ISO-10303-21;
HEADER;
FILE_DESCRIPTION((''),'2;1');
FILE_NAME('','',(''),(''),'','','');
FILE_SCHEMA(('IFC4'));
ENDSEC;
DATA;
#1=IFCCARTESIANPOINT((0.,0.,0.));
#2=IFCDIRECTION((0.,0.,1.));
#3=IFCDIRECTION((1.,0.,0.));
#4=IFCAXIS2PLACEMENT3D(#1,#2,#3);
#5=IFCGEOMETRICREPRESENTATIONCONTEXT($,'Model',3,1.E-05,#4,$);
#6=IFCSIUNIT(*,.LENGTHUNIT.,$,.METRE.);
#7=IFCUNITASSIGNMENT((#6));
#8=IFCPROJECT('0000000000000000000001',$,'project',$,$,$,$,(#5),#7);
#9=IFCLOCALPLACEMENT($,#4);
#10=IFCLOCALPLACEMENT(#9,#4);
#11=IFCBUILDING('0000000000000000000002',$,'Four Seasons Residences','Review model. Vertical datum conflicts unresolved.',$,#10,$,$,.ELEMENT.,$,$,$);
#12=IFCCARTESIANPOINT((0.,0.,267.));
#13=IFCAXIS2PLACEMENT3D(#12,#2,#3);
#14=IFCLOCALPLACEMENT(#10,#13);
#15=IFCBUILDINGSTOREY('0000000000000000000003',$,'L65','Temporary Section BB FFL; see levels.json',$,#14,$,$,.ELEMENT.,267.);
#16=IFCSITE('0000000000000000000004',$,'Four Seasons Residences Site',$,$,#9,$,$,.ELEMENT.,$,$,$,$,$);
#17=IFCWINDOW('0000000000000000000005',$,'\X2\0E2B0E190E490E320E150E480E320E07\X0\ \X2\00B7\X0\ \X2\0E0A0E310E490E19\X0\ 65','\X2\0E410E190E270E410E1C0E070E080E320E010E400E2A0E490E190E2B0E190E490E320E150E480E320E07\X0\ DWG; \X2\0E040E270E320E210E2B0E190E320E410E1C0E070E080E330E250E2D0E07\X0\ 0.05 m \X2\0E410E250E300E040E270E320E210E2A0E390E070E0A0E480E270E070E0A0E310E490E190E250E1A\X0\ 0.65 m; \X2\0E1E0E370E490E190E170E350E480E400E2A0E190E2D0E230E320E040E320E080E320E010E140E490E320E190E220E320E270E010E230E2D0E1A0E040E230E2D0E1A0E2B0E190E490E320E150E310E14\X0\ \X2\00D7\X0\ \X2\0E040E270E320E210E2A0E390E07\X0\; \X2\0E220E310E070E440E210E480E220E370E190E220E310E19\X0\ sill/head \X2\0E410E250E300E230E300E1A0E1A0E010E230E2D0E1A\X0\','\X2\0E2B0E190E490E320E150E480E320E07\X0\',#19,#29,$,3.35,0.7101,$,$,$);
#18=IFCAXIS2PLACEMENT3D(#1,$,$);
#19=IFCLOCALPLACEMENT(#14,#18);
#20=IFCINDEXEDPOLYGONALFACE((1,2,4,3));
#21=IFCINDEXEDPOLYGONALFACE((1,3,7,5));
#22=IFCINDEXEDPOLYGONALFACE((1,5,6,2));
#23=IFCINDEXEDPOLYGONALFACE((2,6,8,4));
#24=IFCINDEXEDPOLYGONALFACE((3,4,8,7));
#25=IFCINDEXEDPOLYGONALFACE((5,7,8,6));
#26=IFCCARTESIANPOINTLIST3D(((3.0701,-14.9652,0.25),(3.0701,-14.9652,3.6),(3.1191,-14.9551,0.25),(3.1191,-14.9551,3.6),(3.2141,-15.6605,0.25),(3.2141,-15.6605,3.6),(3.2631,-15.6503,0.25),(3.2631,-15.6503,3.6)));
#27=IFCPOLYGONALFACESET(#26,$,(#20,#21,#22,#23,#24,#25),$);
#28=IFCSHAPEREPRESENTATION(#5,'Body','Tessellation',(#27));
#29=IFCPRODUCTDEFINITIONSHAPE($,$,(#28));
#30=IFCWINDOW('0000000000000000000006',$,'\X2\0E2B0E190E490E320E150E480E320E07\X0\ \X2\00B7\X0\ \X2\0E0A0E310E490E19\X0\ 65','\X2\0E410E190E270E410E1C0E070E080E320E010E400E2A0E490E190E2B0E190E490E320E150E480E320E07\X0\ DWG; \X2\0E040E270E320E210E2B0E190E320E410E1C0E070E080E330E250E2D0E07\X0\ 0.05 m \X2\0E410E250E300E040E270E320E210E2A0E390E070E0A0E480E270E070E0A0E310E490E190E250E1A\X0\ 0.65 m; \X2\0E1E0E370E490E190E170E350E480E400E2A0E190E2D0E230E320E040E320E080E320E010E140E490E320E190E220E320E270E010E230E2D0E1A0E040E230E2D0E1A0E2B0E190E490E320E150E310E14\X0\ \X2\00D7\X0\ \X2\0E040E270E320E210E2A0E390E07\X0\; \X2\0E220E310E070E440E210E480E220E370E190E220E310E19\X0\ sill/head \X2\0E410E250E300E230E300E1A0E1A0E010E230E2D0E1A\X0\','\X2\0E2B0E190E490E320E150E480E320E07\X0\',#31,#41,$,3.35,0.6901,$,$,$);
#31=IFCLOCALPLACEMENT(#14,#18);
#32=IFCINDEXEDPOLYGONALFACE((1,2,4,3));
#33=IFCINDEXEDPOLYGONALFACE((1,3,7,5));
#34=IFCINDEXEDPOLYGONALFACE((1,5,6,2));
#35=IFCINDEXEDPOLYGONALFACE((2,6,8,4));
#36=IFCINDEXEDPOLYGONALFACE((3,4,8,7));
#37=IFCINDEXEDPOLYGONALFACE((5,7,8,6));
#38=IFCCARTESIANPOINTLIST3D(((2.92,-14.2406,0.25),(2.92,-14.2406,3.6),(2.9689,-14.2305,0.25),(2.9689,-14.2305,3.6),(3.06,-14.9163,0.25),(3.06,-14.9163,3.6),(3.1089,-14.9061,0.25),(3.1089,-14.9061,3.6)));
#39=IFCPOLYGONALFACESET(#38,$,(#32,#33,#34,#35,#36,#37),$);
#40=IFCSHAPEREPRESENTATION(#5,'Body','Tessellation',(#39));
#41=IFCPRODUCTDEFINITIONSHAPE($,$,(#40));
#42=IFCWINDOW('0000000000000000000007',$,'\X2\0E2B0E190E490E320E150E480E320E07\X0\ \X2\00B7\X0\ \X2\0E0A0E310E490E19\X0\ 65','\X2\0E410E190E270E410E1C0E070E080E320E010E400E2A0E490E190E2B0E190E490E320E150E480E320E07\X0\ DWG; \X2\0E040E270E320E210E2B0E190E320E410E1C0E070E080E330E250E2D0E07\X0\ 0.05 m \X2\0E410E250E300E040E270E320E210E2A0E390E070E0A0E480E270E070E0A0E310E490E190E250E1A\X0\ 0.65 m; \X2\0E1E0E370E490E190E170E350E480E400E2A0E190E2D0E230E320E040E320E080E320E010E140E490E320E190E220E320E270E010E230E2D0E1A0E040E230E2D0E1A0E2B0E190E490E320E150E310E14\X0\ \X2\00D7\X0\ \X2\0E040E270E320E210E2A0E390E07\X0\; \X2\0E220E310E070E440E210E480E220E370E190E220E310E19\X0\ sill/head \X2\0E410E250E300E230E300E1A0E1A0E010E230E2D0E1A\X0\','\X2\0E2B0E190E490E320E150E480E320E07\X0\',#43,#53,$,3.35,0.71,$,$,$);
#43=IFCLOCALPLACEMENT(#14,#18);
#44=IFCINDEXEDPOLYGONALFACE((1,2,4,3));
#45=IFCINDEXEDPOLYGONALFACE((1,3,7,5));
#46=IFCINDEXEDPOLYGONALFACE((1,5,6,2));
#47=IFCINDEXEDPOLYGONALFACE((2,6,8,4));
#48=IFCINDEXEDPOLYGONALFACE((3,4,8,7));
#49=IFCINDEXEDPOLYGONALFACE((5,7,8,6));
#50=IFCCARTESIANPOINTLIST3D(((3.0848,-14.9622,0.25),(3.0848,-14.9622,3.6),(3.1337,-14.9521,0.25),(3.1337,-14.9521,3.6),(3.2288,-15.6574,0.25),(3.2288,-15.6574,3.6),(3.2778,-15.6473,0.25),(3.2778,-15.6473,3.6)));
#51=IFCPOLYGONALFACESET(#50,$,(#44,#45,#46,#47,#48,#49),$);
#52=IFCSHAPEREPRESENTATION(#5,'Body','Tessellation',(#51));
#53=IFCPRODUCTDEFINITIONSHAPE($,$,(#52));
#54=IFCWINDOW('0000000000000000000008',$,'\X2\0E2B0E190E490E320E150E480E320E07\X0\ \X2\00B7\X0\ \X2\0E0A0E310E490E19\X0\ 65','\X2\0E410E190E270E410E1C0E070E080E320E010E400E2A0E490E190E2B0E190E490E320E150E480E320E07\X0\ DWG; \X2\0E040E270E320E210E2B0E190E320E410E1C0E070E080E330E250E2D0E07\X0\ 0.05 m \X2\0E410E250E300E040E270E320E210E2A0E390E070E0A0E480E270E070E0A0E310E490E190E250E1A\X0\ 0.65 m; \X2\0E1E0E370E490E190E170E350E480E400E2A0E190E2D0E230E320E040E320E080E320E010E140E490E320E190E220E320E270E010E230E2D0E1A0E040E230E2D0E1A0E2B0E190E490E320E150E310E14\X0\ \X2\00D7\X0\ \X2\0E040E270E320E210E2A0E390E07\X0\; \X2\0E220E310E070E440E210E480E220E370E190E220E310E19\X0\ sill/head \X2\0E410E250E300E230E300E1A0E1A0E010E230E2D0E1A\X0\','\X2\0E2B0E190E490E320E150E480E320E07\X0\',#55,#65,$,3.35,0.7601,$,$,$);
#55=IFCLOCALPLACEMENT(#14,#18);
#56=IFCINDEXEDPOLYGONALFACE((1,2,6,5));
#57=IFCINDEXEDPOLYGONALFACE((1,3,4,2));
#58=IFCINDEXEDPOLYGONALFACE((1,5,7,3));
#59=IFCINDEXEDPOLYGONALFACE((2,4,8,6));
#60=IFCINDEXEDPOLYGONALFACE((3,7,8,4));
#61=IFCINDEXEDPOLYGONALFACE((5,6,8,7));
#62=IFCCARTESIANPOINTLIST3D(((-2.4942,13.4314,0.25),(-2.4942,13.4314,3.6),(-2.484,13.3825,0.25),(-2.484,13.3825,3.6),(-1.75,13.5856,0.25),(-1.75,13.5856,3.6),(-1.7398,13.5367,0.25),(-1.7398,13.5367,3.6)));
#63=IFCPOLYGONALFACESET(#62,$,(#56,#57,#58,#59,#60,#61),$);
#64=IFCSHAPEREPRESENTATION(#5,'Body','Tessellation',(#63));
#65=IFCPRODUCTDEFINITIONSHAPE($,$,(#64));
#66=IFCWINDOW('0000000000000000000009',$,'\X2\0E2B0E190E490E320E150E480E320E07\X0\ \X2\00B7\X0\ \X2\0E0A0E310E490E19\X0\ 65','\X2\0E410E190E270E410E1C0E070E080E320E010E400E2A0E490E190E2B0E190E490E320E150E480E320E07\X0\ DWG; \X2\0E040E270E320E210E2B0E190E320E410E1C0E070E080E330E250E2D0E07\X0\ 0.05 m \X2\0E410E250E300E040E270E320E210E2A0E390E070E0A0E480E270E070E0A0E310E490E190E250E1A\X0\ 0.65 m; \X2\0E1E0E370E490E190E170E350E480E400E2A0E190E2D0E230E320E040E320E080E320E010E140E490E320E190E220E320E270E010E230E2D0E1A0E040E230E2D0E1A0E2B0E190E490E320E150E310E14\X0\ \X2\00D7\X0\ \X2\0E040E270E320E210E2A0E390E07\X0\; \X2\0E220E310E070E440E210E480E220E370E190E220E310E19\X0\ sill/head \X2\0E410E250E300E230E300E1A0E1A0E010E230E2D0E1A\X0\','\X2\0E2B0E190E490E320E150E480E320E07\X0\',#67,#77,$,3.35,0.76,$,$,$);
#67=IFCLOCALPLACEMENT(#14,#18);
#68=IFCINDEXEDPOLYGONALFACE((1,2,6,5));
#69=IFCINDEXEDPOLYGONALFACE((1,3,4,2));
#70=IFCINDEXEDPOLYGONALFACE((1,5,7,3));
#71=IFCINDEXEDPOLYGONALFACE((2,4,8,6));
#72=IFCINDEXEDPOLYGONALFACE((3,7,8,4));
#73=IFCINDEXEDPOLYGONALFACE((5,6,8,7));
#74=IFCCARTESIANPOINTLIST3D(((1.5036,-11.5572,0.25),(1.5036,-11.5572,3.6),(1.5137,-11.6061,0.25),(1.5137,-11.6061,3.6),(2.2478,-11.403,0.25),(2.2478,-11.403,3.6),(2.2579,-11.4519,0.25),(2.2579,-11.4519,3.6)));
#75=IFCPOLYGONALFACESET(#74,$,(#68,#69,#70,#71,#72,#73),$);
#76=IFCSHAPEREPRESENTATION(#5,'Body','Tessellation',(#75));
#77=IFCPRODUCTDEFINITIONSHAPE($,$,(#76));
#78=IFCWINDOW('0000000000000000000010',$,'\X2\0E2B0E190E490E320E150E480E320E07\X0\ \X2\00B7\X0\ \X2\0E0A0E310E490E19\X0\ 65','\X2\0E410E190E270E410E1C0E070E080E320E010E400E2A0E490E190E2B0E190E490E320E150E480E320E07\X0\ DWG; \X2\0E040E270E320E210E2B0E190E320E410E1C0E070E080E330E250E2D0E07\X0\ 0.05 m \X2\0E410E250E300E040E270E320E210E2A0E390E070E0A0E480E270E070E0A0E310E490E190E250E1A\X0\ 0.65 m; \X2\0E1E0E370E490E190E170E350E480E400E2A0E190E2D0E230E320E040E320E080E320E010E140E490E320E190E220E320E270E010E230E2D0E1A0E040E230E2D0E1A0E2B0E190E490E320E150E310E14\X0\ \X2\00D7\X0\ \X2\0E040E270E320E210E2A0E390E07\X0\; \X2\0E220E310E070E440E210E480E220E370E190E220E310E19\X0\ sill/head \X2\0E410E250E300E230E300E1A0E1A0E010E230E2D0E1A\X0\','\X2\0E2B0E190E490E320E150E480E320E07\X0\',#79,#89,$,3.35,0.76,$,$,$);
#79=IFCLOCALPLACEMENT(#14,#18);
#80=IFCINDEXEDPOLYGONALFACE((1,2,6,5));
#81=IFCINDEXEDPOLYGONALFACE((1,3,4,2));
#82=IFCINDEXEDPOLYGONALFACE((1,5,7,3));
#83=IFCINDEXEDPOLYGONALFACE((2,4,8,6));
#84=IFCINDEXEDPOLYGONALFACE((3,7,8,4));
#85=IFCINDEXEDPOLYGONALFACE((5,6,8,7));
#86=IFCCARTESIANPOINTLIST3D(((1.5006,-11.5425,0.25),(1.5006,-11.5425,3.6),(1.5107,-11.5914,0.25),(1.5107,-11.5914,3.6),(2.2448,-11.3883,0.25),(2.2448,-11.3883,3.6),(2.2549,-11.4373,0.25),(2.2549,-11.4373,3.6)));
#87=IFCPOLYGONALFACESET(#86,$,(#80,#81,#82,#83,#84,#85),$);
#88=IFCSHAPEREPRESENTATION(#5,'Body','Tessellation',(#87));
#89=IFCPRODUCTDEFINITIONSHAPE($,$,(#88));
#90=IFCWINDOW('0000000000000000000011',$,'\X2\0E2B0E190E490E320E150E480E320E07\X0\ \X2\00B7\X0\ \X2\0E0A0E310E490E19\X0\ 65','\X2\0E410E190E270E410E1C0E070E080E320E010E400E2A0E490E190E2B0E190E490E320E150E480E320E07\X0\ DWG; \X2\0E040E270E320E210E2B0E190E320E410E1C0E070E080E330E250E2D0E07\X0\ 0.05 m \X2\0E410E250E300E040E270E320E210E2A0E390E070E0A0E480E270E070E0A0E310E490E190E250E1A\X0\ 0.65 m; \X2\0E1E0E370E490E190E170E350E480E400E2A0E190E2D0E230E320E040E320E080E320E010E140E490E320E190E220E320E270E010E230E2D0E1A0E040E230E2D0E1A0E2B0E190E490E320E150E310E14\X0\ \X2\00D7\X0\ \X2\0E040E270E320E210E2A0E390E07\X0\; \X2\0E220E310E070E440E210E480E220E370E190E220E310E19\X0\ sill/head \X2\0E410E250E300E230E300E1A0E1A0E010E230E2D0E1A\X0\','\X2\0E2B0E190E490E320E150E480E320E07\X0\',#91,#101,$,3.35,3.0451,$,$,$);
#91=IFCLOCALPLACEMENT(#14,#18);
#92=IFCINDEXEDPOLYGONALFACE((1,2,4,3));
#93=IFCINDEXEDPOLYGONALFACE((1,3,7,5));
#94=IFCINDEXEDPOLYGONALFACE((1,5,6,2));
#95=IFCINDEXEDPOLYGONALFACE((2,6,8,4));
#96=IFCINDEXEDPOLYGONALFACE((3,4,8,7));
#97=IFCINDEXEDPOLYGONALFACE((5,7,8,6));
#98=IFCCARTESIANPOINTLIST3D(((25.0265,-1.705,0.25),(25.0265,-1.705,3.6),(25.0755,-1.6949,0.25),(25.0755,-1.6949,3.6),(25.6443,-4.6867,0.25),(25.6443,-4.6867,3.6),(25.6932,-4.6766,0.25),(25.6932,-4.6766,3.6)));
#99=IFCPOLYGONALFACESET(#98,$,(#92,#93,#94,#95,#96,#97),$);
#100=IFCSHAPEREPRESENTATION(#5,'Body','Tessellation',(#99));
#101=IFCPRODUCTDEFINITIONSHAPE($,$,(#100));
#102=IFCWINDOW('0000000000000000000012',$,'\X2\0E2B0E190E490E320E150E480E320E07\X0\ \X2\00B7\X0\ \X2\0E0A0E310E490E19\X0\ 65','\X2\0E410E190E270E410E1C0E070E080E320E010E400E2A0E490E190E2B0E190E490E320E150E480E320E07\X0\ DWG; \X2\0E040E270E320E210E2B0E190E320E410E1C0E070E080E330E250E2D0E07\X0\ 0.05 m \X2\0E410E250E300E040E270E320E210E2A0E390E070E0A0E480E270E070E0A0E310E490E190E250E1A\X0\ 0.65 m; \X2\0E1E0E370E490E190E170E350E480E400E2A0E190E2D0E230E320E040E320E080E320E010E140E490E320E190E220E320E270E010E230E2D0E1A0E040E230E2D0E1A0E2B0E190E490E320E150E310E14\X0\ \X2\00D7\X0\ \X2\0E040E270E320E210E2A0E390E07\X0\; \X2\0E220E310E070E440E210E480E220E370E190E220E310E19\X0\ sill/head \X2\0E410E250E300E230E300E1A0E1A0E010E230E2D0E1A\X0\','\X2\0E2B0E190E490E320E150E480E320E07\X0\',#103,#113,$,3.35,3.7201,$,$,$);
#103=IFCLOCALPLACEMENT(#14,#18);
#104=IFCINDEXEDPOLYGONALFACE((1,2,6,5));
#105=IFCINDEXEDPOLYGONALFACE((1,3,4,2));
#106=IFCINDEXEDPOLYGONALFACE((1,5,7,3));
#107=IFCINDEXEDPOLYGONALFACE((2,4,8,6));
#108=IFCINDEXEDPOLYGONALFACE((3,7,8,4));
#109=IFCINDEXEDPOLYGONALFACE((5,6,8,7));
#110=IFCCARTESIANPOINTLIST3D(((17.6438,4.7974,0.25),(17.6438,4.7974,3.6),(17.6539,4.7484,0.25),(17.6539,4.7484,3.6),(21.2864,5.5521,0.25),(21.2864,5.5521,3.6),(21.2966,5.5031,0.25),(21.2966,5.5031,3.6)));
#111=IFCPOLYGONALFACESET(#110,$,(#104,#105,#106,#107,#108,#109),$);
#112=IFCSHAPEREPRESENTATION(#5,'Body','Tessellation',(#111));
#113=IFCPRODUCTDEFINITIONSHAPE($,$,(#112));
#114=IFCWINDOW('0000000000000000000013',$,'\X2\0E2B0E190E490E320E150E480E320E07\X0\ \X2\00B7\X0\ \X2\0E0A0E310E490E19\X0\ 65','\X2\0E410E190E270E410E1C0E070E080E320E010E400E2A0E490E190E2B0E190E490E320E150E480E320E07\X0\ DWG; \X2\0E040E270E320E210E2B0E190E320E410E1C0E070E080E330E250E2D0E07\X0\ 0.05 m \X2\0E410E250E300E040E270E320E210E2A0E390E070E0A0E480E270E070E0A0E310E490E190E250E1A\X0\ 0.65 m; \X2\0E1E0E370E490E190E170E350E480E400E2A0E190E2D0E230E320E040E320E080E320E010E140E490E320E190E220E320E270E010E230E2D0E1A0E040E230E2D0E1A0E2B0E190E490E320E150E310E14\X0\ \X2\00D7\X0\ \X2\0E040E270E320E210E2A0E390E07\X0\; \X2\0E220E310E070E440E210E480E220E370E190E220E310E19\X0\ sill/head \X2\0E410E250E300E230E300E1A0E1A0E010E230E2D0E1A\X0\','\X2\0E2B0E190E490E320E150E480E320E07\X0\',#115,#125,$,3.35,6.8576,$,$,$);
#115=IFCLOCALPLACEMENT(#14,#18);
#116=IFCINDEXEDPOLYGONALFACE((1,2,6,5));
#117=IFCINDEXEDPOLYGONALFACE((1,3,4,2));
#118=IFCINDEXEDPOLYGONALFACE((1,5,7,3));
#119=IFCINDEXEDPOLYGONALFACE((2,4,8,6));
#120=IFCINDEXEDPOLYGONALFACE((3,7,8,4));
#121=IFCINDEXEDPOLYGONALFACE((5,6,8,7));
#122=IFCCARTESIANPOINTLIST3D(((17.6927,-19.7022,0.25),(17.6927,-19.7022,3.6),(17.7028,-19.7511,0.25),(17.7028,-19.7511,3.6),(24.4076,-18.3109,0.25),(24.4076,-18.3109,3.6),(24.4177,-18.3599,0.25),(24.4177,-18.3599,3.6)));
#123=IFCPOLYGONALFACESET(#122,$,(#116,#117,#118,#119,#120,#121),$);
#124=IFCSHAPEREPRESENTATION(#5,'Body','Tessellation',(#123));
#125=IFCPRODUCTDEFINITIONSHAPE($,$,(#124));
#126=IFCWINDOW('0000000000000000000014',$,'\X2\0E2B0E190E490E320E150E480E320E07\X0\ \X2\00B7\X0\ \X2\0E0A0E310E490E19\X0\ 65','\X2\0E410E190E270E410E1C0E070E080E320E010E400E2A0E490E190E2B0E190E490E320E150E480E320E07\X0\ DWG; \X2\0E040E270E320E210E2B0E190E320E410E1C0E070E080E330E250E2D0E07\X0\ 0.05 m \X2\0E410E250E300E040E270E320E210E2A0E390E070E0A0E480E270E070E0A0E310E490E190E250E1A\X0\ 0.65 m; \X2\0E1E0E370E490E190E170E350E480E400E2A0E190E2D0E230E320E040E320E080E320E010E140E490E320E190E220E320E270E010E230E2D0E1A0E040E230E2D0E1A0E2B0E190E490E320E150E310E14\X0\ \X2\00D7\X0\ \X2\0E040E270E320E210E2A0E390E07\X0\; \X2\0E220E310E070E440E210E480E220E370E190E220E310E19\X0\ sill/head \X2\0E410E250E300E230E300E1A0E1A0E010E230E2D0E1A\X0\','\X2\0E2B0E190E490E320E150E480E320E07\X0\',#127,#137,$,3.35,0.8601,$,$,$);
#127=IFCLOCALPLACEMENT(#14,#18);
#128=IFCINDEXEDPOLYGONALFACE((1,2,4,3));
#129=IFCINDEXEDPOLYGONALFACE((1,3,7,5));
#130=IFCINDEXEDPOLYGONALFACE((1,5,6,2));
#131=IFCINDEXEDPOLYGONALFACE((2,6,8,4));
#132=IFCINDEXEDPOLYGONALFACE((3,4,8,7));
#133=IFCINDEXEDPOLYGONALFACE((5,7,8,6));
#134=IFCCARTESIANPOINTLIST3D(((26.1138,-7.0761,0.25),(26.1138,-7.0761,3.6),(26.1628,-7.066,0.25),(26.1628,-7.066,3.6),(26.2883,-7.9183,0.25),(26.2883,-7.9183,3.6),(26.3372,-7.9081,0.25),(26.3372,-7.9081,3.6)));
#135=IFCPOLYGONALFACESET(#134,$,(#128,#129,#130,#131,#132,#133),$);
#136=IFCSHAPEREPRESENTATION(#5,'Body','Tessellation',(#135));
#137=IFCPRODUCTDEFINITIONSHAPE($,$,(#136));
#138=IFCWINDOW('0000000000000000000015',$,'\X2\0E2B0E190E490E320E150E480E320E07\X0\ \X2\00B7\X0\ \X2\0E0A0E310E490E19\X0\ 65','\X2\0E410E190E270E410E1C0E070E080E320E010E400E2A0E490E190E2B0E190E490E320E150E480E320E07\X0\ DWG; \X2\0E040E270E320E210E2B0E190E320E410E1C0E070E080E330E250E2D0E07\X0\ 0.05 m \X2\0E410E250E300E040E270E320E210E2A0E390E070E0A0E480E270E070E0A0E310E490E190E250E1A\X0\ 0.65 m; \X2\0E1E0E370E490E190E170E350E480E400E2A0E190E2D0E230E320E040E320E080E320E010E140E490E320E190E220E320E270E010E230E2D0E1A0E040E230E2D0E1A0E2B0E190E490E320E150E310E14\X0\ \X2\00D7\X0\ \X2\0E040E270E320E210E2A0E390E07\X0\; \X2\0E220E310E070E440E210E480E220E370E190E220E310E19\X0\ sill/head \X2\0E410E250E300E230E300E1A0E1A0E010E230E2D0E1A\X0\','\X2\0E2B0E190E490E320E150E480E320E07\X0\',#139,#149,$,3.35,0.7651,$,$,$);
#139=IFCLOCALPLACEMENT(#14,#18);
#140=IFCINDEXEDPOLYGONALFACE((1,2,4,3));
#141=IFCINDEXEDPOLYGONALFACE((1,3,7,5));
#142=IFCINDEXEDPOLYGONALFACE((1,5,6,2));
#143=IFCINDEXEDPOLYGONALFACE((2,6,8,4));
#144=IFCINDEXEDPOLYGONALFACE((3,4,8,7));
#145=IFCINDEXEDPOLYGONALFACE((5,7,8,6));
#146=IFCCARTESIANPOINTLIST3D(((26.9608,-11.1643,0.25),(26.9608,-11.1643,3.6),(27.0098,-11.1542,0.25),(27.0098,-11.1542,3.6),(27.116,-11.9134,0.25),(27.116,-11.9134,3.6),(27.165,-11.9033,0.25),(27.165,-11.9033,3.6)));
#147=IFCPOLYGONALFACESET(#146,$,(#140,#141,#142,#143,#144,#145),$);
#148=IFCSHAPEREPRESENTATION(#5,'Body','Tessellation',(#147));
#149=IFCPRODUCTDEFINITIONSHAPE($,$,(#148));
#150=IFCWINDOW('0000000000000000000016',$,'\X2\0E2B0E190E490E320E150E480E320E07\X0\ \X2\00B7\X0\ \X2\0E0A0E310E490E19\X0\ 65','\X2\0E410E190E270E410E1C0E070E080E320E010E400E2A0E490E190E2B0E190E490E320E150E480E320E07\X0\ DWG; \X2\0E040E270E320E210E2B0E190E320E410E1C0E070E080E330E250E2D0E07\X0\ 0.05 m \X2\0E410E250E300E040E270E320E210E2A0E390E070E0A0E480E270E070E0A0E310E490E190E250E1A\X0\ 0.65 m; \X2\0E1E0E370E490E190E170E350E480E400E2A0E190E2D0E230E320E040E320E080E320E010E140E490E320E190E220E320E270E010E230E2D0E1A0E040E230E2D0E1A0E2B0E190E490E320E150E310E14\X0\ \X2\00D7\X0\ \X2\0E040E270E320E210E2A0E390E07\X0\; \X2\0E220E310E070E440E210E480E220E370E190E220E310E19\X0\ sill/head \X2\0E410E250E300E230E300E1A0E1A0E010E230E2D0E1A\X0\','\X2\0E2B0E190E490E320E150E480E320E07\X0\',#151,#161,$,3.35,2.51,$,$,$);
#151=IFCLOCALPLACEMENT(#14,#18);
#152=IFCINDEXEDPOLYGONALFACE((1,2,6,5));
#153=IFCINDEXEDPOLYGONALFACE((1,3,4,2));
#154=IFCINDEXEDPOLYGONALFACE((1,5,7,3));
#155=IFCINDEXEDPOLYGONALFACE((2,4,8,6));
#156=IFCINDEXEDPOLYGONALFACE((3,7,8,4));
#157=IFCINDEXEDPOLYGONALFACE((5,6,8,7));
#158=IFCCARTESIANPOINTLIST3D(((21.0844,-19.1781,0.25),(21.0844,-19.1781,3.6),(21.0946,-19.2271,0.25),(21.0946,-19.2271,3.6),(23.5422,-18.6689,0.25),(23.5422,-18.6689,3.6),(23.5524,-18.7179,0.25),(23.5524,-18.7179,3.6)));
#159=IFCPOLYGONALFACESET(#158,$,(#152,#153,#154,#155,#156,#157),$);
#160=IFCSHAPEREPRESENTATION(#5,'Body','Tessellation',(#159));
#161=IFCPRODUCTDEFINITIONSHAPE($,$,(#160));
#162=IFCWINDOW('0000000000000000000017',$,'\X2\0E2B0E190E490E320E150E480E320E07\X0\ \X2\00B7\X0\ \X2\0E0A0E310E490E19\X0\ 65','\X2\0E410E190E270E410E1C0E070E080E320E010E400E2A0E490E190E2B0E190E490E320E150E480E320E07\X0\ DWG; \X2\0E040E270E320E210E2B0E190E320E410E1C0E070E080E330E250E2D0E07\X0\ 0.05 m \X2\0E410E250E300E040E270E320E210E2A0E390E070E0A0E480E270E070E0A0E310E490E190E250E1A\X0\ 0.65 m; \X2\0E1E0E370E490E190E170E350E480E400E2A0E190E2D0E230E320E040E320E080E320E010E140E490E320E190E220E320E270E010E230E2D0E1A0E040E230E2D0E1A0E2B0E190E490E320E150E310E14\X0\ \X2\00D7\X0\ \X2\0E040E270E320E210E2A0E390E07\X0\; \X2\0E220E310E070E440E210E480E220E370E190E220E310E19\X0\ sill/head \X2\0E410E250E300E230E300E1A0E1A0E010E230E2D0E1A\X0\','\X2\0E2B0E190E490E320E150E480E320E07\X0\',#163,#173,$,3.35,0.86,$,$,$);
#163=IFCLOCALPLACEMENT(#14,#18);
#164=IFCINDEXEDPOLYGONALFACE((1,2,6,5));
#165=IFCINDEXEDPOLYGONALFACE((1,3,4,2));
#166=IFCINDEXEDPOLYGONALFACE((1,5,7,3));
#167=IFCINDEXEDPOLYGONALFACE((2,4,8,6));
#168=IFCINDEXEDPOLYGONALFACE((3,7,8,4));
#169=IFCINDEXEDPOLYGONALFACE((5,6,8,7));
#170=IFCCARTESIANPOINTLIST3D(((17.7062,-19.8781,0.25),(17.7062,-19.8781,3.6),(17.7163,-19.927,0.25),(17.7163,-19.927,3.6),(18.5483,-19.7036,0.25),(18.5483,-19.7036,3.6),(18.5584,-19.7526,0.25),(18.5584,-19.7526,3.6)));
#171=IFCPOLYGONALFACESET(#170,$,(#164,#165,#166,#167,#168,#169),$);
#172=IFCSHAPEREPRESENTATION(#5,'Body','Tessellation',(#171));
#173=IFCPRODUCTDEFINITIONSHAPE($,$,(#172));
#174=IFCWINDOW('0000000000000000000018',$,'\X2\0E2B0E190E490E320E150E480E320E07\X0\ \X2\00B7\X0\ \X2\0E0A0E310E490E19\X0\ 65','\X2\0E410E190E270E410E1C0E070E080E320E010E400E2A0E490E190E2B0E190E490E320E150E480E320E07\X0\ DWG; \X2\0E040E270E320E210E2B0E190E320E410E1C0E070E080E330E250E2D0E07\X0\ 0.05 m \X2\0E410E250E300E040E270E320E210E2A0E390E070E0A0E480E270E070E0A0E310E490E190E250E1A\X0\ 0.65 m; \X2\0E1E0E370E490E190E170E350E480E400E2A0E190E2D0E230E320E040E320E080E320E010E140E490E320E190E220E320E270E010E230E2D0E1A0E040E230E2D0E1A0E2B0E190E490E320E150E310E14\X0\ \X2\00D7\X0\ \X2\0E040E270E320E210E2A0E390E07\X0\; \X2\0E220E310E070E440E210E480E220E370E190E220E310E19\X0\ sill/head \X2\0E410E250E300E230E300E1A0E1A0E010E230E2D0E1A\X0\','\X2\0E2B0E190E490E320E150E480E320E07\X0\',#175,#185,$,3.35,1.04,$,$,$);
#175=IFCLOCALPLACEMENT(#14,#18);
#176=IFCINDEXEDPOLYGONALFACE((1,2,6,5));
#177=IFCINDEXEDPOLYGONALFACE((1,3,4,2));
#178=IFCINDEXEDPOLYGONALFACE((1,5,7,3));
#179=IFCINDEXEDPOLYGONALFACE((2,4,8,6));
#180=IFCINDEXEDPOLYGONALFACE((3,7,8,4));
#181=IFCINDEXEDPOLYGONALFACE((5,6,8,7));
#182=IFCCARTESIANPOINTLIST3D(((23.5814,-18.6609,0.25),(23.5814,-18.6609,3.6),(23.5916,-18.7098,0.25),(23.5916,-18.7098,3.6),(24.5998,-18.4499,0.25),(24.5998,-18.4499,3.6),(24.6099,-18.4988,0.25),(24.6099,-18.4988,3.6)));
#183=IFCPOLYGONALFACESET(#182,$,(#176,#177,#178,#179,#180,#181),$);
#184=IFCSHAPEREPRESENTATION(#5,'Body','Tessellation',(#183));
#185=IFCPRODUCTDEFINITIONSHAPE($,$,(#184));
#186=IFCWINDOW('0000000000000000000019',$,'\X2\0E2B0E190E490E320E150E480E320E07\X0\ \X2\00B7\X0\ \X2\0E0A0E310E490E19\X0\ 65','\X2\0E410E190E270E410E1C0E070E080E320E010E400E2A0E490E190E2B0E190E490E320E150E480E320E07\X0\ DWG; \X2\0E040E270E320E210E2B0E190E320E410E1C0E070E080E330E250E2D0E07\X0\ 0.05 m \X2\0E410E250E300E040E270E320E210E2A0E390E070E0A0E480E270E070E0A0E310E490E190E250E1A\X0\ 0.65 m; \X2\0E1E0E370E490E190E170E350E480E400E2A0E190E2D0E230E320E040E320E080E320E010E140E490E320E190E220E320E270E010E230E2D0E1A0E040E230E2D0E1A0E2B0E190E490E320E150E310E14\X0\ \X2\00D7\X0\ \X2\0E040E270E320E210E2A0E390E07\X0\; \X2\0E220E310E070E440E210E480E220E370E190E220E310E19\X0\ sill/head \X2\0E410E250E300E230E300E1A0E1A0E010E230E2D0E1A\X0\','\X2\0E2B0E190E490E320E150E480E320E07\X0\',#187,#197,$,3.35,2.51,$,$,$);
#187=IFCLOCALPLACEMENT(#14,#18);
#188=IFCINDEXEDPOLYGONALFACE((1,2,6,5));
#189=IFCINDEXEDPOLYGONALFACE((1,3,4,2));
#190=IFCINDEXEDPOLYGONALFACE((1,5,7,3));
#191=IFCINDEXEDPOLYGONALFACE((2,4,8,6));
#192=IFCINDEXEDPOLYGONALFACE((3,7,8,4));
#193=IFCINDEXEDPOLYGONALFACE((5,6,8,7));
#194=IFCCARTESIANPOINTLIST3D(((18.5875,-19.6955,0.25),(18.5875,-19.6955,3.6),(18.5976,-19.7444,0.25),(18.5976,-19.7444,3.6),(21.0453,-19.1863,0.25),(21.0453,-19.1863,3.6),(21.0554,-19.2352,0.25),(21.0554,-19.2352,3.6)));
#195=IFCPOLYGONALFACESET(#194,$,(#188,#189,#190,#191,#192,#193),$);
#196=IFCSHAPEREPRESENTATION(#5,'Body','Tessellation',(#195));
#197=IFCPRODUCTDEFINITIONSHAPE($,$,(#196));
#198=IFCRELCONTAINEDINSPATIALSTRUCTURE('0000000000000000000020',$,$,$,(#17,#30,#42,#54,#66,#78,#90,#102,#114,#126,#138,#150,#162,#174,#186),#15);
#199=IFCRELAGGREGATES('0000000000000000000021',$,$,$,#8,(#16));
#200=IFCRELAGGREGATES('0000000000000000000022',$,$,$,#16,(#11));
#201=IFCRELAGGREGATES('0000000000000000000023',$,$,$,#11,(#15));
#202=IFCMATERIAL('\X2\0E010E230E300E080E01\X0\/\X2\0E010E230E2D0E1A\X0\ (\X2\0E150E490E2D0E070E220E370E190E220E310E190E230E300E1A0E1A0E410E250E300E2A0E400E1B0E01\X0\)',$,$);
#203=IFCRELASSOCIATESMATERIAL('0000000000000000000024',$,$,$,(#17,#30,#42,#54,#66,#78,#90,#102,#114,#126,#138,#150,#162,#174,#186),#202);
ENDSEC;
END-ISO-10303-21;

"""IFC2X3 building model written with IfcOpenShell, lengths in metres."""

from ifc_helpers import new_model, si_unit, frame, origin_with_axes, place, context, project, spatial, polyline, outline, extrude, material, element, save


model = new_model("IFC2X3")

# Units and contexts
model_context = context("Model", 3, precision=1e-05, world=origin_with_axes())
ifc_project = project(units=[si_unit("LENGTHUNIT", "METRE")], contexts=[model_context])

# Site, building, storey
site_placement = place(None, origin_with_axes())
site = spatial("IfcSite", under=ifc_project, at=site_placement, Name="Four Seasons Residences Site", CompositionType="ELEMENT")
building_placement = place(site_placement, origin_with_axes())
building = spatial("IfcBuilding", under=site, at=building_placement, Name="Four Seasons Residences", Description="Review model. Vertical datum conflicts unresolved.", CompositionType="ELEMENT")
storey_placement = place(building_placement, frame((0.0, 0.0, 267.0), z_axis=(0.0, 0.0, 1.0), x_axis=(1.0, 0.0, 0.0)))
storey = spatial("IfcBuildingStorey", under=building, at=storey_placement, Name="L65", Description="Temporary Section BB FFL; see levels.json", CompositionType="ELEMENT", Elevation=267.0)

# Windows
ifc_material = material(Name="กระจก/กรอบ (ต้องยืนยันระบบและสเปก)")
window_1_placement = place(storey_placement, origin_with_axes())
element("IfcWindow", 1, at=window_1_placement, inside=storey, material=ifc_material, Name="หน้าต่าง · ชั้น 65", Description="แนวแผงจากเส้นหน้าต่าง DWG; ความหนาแผงจำลอง 0.05 m และความสูงช่วงชั้นลบ 0.65 m; พื้นที่เสนอราคาจากด้านยาวกรอบครอบหน้าตัด × ความสูง; ยังไม่ยืนยัน sill/head และระบบกรอบ", ObjectType="หน้าต่าง", OverallHeight=3.35, OverallWidth=0.7101, context=model_context, shape_type="SweptSolid", body=[
    extrude(outline(polyline([(3.0701, -14.9652), (3.1191, -14.9551), (3.2631, -15.6503), (3.2141, -15.6605), (3.0701, -14.9652)])), frame((0.0, 0.0, 0.25), z_axis=(0.0, 0.0, 1.0), x_axis=(1.0, 0.0, 0.0)), (0.0, 0.0, 1.0), 3.35),
])
window_2_placement = place(storey_placement, origin_with_axes())
element("IfcWindow", 2, at=window_2_placement, inside=storey, material=ifc_material, Name="หน้าต่าง · ชั้น 65", Description="แนวแผงจากเส้นหน้าต่าง DWG; ความหนาแผงจำลอง 0.05 m และความสูงช่วงชั้นลบ 0.65 m; พื้นที่เสนอราคาจากด้านยาวกรอบครอบหน้าตัด × ความสูง; ยังไม่ยืนยัน sill/head และระบบกรอบ", ObjectType="หน้าต่าง", OverallHeight=3.35, OverallWidth=0.6901, context=model_context, shape_type="SweptSolid", body=[
    extrude(outline(polyline([(2.92, -14.2406), (2.9689, -14.2305), (3.1089, -14.9061), (3.06, -14.9163), (2.92, -14.2406)])), frame((0.0, 0.0, 0.25), z_axis=(0.0, 0.0, 1.0), x_axis=(1.0, 0.0, 0.0)), (0.0, 0.0, 1.0), 3.35),
])
window_3_placement = place(storey_placement, origin_with_axes())
element("IfcWindow", 3, at=window_3_placement, inside=storey, material=ifc_material, Name="หน้าต่าง · ชั้น 65", Description="แนวแผงจากเส้นหน้าต่าง DWG; ความหนาแผงจำลอง 0.05 m และความสูงช่วงชั้นลบ 0.65 m; พื้นที่เสนอราคาจากด้านยาวกรอบครอบหน้าตัด × ความสูง; ยังไม่ยืนยัน sill/head และระบบกรอบ", ObjectType="หน้าต่าง", OverallHeight=3.35, OverallWidth=0.71, context=model_context, shape_type="SweptSolid", body=[
    extrude(outline(polyline([(3.0848, -14.9622), (3.1337, -14.9521), (3.2778, -15.6473), (3.2288, -15.6574), (3.0848, -14.9622)])), frame((0.0, 0.0, 0.25), z_axis=(0.0, 0.0, 1.0), x_axis=(1.0, 0.0, 0.0)), (0.0, 0.0, 1.0), 3.35),
])
window_4_placement = place(storey_placement, origin_with_axes())
element("IfcWindow", 4, at=window_4_placement, inside=storey, material=ifc_material, Name="หน้าต่าง · ชั้น 65", Description="แนวแผงจากเส้นหน้าต่าง DWG; ความหนาแผงจำลอง 0.05 m และความสูงช่วงชั้นลบ 0.65 m; พื้นที่เสนอราคาจากด้านยาวกรอบครอบหน้าตัด × ความสูง; ยังไม่ยืนยัน sill/head และระบบกรอบ", ObjectType="หน้าต่าง", OverallHeight=3.35, OverallWidth=0.7601, context=model_context, shape_type="SweptSolid", body=[
    extrude(outline(polyline([(-1.75, 13.5856), (-1.7398, 13.5367), (-2.484, 13.3825), (-2.4942, 13.4314), (-1.75, 13.5856)])), frame((0.0, 0.0, 0.25), z_axis=(0.0, 0.0, 1.0), x_axis=(1.0, 0.0, 0.0)), (0.0, 0.0, 1.0), 3.35),
])
window_5_placement = place(storey_placement, origin_with_axes())
element("IfcWindow", 5, at=window_5_placement, inside=storey, material=ifc_material, Name="หน้าต่าง · ชั้น 65", Description="แนวแผงจากเส้นหน้าต่าง DWG; ความหนาแผงจำลอง 0.05 m และความสูงช่วงชั้นลบ 0.65 m; พื้นที่เสนอราคาจากด้านยาวกรอบครอบหน้าตัด × ความสูง; ยังไม่ยืนยัน sill/head และระบบกรอบ", ObjectType="หน้าต่าง", OverallHeight=3.35, OverallWidth=0.76, context=model_context, shape_type="SweptSolid", body=[
    extrude(outline(polyline([(2.2478, -11.403), (2.2579, -11.4519), (1.5137, -11.6061), (1.5036, -11.5572), (2.2478, -11.403)])), frame((0.0, 0.0, 0.25), z_axis=(0.0, 0.0, 1.0), x_axis=(1.0, 0.0, 0.0)), (0.0, 0.0, 1.0), 3.35),
])
window_6_placement = place(storey_placement, origin_with_axes())
element("IfcWindow", 6, at=window_6_placement, inside=storey, material=ifc_material, Name="หน้าต่าง · ชั้น 65", Description="แนวแผงจากเส้นหน้าต่าง DWG; ความหนาแผงจำลอง 0.05 m และความสูงช่วงชั้นลบ 0.65 m; พื้นที่เสนอราคาจากด้านยาวกรอบครอบหน้าตัด × ความสูง; ยังไม่ยืนยัน sill/head และระบบกรอบ", ObjectType="หน้าต่าง", OverallHeight=3.35, OverallWidth=0.76, context=model_context, shape_type="SweptSolid", body=[
    extrude(outline(polyline([(2.2448, -11.3883), (2.2549, -11.4373), (1.5107, -11.5914), (1.5006, -11.5425), (2.2448, -11.3883)])), frame((0.0, 0.0, 0.25), z_axis=(0.0, 0.0, 1.0), x_axis=(1.0, 0.0, 0.0)), (0.0, 0.0, 1.0), 3.35),
])
window_7_placement = place(storey_placement, origin_with_axes())
element("IfcWindow", 7, at=window_7_placement, inside=storey, material=ifc_material, Name="หน้าต่าง · ชั้น 65", Description="แนวแผงจากเส้นหน้าต่าง DWG; ความหนาแผงจำลอง 0.05 m และความสูงช่วงชั้นลบ 0.65 m; พื้นที่เสนอราคาจากด้านยาวกรอบครอบหน้าตัด × ความสูง; ยังไม่ยืนยัน sill/head และระบบกรอบ", ObjectType="หน้าต่าง", OverallHeight=3.35, OverallWidth=3.0451, context=model_context, shape_type="SweptSolid", body=[
    extrude(outline(polyline([(25.0265, -1.705), (25.0755, -1.6949), (25.6932, -4.6766), (25.6443, -4.6867), (25.0265, -1.705)])), frame((0.0, 0.0, 0.25), z_axis=(0.0, 0.0, 1.0), x_axis=(1.0, 0.0, 0.0)), (0.0, 0.0, 1.0), 3.35),
])
window_8_placement = place(storey_placement, origin_with_axes())
element("IfcWindow", 8, at=window_8_placement, inside=storey, material=ifc_material, Name="หน้าต่าง · ชั้น 65", Description="แนวแผงจากเส้นหน้าต่าง DWG; ความหนาแผงจำลอง 0.05 m และความสูงช่วงชั้นลบ 0.65 m; พื้นที่เสนอราคาจากด้านยาวกรอบครอบหน้าตัด × ความสูง; ยังไม่ยืนยัน sill/head และระบบกรอบ", ObjectType="หน้าต่าง", OverallHeight=3.35, OverallWidth=3.7201, context=model_context, shape_type="SweptSolid", body=[
    extrude(outline(polyline([(17.6539, 4.7484), (17.6438, 4.7974), (21.2864, 5.5521), (21.2966, 5.5031), (17.6539, 4.7484)])), frame((0.0, 0.0, 0.25), z_axis=(0.0, 0.0, 1.0), x_axis=(1.0, 0.0, 0.0)), (0.0, 0.0, 1.0), 3.35),
])
window_9_placement = place(storey_placement, origin_with_axes())
element("IfcWindow", 9, at=window_9_placement, inside=storey, material=ifc_material, Name="หน้าต่าง · ชั้น 65", Description="แนวแผงจากเส้นหน้าต่าง DWG; ความหนาแผงจำลอง 0.05 m และความสูงช่วงชั้นลบ 0.65 m; พื้นที่เสนอราคาจากด้านยาวกรอบครอบหน้าตัด × ความสูง; ยังไม่ยืนยัน sill/head และระบบกรอบ", ObjectType="หน้าต่าง", OverallHeight=3.35, OverallWidth=6.8576, context=model_context, shape_type="SweptSolid", body=[
    extrude(outline(polyline([(17.7028, -19.7511), (17.6927, -19.7022), (24.4076, -18.3109), (24.4177, -18.3599), (17.7028, -19.7511)])), frame((0.0, 0.0, 0.25), z_axis=(0.0, 0.0, 1.0), x_axis=(1.0, 0.0, 0.0)), (0.0, 0.0, 1.0), 3.35),
])
window_10_placement = place(storey_placement, origin_with_axes())
element("IfcWindow", 10, at=window_10_placement, inside=storey, material=ifc_material, Name="หน้าต่าง · ชั้น 65", Description="แนวแผงจากเส้นหน้าต่าง DWG; ความหนาแผงจำลอง 0.05 m และความสูงช่วงชั้นลบ 0.65 m; พื้นที่เสนอราคาจากด้านยาวกรอบครอบหน้าตัด × ความสูง; ยังไม่ยืนยัน sill/head และระบบกรอบ", ObjectType="หน้าต่าง", OverallHeight=3.35, OverallWidth=0.8601, context=model_context, shape_type="SweptSolid", body=[
    extrude(outline(polyline([(26.3372, -7.9081), (26.2883, -7.9183), (26.1138, -7.0761), (26.1628, -7.066), (26.3372, -7.9081)])), frame((0.0, 0.0, 0.25), z_axis=(0.0, 0.0, 1.0), x_axis=(1.0, 0.0, 0.0)), (0.0, 0.0, 1.0), 3.35),
])
window_11_placement = place(storey_placement, origin_with_axes())
element("IfcWindow", 11, at=window_11_placement, inside=storey, material=ifc_material, Name="หน้าต่าง · ชั้น 65", Description="แนวแผงจากเส้นหน้าต่าง DWG; ความหนาแผงจำลอง 0.05 m และความสูงช่วงชั้นลบ 0.65 m; พื้นที่เสนอราคาจากด้านยาวกรอบครอบหน้าตัด × ความสูง; ยังไม่ยืนยัน sill/head และระบบกรอบ", ObjectType="หน้าต่าง", OverallHeight=3.35, OverallWidth=0.7651, context=model_context, shape_type="SweptSolid", body=[
    extrude(outline(polyline([(27.165, -11.9033), (27.116, -11.9134), (26.9608, -11.1643), (27.0098, -11.1542), (27.165, -11.9033)])), frame((0.0, 0.0, 0.25), z_axis=(0.0, 0.0, 1.0), x_axis=(1.0, 0.0, 0.0)), (0.0, 0.0, 1.0), 3.35),
])
window_12_placement = place(storey_placement, origin_with_axes())
element("IfcWindow", 12, at=window_12_placement, inside=storey, material=ifc_material, Name="หน้าต่าง · ชั้น 65", Description="แนวแผงจากเส้นหน้าต่าง DWG; ความหนาแผงจำลอง 0.05 m และความสูงช่วงชั้นลบ 0.65 m; พื้นที่เสนอราคาจากด้านยาวกรอบครอบหน้าตัด × ความสูง; ยังไม่ยืนยัน sill/head และระบบกรอบ", ObjectType="หน้าต่าง", OverallHeight=3.35, OverallWidth=2.51, context=model_context, shape_type="SweptSolid", body=[
    extrude(outline(polyline([(21.0946, -19.2271), (21.0844, -19.1781), (23.5422, -18.6689), (23.5524, -18.7179), (21.0946, -19.2271)])), frame((0.0, 0.0, 0.25), z_axis=(0.0, 0.0, 1.0), x_axis=(1.0, 0.0, 0.0)), (0.0, 0.0, 1.0), 3.35),
])
window_13_placement = place(storey_placement, origin_with_axes())
element("IfcWindow", 13, at=window_13_placement, inside=storey, material=ifc_material, Name="หน้าต่าง · ชั้น 65", Description="แนวแผงจากเส้นหน้าต่าง DWG; ความหนาแผงจำลอง 0.05 m และความสูงช่วงชั้นลบ 0.65 m; พื้นที่เสนอราคาจากด้านยาวกรอบครอบหน้าตัด × ความสูง; ยังไม่ยืนยัน sill/head และระบบกรอบ", ObjectType="หน้าต่าง", OverallHeight=3.35, OverallWidth=0.86, context=model_context, shape_type="SweptSolid", body=[
    extrude(outline(polyline([(17.7163, -19.927), (17.7062, -19.8781), (18.5483, -19.7036), (18.5584, -19.7526), (17.7163, -19.927)])), frame((0.0, 0.0, 0.25), z_axis=(0.0, 0.0, 1.0), x_axis=(1.0, 0.0, 0.0)), (0.0, 0.0, 1.0), 3.35),
])
window_14_placement = place(storey_placement, origin_with_axes())
element("IfcWindow", 14, at=window_14_placement, inside=storey, material=ifc_material, Name="หน้าต่าง · ชั้น 65", Description="แนวแผงจากเส้นหน้าต่าง DWG; ความหนาแผงจำลอง 0.05 m และความสูงช่วงชั้นลบ 0.65 m; พื้นที่เสนอราคาจากด้านยาวกรอบครอบหน้าตัด × ความสูง; ยังไม่ยืนยัน sill/head และระบบกรอบ", ObjectType="หน้าต่าง", OverallHeight=3.35, OverallWidth=1.04, context=model_context, shape_type="SweptSolid", body=[
    extrude(outline(polyline([(23.5916, -18.7098), (23.5814, -18.6609), (24.5998, -18.4499), (24.6099, -18.4988), (23.5916, -18.7098)])), frame((0.0, 0.0, 0.25), z_axis=(0.0, 0.0, 1.0), x_axis=(1.0, 0.0, 0.0)), (0.0, 0.0, 1.0), 3.35),
])
window_15_placement = place(storey_placement, origin_with_axes())
element("IfcWindow", 15, at=window_15_placement, inside=storey, material=ifc_material, Name="หน้าต่าง · ชั้น 65", Description="แนวแผงจากเส้นหน้าต่าง DWG; ความหนาแผงจำลอง 0.05 m และความสูงช่วงชั้นลบ 0.65 m; พื้นที่เสนอราคาจากด้านยาวกรอบครอบหน้าตัด × ความสูง; ยังไม่ยืนยัน sill/head และระบบกรอบ", ObjectType="หน้าต่าง", OverallHeight=3.35, OverallWidth=2.51, context=model_context, shape_type="SweptSolid", body=[
    extrude(outline(polyline([(18.5976, -19.7444), (18.5875, -19.6955), (21.0453, -19.1863), (21.0554, -19.2352), (18.5976, -19.7444)])), frame((0.0, 0.0, 0.25), z_axis=(0.0, 0.0, 1.0), x_axis=(1.0, 0.0, 0.0)), (0.0, 0.0, 1.0), 3.35),
])

save(model, "model.ifc")
